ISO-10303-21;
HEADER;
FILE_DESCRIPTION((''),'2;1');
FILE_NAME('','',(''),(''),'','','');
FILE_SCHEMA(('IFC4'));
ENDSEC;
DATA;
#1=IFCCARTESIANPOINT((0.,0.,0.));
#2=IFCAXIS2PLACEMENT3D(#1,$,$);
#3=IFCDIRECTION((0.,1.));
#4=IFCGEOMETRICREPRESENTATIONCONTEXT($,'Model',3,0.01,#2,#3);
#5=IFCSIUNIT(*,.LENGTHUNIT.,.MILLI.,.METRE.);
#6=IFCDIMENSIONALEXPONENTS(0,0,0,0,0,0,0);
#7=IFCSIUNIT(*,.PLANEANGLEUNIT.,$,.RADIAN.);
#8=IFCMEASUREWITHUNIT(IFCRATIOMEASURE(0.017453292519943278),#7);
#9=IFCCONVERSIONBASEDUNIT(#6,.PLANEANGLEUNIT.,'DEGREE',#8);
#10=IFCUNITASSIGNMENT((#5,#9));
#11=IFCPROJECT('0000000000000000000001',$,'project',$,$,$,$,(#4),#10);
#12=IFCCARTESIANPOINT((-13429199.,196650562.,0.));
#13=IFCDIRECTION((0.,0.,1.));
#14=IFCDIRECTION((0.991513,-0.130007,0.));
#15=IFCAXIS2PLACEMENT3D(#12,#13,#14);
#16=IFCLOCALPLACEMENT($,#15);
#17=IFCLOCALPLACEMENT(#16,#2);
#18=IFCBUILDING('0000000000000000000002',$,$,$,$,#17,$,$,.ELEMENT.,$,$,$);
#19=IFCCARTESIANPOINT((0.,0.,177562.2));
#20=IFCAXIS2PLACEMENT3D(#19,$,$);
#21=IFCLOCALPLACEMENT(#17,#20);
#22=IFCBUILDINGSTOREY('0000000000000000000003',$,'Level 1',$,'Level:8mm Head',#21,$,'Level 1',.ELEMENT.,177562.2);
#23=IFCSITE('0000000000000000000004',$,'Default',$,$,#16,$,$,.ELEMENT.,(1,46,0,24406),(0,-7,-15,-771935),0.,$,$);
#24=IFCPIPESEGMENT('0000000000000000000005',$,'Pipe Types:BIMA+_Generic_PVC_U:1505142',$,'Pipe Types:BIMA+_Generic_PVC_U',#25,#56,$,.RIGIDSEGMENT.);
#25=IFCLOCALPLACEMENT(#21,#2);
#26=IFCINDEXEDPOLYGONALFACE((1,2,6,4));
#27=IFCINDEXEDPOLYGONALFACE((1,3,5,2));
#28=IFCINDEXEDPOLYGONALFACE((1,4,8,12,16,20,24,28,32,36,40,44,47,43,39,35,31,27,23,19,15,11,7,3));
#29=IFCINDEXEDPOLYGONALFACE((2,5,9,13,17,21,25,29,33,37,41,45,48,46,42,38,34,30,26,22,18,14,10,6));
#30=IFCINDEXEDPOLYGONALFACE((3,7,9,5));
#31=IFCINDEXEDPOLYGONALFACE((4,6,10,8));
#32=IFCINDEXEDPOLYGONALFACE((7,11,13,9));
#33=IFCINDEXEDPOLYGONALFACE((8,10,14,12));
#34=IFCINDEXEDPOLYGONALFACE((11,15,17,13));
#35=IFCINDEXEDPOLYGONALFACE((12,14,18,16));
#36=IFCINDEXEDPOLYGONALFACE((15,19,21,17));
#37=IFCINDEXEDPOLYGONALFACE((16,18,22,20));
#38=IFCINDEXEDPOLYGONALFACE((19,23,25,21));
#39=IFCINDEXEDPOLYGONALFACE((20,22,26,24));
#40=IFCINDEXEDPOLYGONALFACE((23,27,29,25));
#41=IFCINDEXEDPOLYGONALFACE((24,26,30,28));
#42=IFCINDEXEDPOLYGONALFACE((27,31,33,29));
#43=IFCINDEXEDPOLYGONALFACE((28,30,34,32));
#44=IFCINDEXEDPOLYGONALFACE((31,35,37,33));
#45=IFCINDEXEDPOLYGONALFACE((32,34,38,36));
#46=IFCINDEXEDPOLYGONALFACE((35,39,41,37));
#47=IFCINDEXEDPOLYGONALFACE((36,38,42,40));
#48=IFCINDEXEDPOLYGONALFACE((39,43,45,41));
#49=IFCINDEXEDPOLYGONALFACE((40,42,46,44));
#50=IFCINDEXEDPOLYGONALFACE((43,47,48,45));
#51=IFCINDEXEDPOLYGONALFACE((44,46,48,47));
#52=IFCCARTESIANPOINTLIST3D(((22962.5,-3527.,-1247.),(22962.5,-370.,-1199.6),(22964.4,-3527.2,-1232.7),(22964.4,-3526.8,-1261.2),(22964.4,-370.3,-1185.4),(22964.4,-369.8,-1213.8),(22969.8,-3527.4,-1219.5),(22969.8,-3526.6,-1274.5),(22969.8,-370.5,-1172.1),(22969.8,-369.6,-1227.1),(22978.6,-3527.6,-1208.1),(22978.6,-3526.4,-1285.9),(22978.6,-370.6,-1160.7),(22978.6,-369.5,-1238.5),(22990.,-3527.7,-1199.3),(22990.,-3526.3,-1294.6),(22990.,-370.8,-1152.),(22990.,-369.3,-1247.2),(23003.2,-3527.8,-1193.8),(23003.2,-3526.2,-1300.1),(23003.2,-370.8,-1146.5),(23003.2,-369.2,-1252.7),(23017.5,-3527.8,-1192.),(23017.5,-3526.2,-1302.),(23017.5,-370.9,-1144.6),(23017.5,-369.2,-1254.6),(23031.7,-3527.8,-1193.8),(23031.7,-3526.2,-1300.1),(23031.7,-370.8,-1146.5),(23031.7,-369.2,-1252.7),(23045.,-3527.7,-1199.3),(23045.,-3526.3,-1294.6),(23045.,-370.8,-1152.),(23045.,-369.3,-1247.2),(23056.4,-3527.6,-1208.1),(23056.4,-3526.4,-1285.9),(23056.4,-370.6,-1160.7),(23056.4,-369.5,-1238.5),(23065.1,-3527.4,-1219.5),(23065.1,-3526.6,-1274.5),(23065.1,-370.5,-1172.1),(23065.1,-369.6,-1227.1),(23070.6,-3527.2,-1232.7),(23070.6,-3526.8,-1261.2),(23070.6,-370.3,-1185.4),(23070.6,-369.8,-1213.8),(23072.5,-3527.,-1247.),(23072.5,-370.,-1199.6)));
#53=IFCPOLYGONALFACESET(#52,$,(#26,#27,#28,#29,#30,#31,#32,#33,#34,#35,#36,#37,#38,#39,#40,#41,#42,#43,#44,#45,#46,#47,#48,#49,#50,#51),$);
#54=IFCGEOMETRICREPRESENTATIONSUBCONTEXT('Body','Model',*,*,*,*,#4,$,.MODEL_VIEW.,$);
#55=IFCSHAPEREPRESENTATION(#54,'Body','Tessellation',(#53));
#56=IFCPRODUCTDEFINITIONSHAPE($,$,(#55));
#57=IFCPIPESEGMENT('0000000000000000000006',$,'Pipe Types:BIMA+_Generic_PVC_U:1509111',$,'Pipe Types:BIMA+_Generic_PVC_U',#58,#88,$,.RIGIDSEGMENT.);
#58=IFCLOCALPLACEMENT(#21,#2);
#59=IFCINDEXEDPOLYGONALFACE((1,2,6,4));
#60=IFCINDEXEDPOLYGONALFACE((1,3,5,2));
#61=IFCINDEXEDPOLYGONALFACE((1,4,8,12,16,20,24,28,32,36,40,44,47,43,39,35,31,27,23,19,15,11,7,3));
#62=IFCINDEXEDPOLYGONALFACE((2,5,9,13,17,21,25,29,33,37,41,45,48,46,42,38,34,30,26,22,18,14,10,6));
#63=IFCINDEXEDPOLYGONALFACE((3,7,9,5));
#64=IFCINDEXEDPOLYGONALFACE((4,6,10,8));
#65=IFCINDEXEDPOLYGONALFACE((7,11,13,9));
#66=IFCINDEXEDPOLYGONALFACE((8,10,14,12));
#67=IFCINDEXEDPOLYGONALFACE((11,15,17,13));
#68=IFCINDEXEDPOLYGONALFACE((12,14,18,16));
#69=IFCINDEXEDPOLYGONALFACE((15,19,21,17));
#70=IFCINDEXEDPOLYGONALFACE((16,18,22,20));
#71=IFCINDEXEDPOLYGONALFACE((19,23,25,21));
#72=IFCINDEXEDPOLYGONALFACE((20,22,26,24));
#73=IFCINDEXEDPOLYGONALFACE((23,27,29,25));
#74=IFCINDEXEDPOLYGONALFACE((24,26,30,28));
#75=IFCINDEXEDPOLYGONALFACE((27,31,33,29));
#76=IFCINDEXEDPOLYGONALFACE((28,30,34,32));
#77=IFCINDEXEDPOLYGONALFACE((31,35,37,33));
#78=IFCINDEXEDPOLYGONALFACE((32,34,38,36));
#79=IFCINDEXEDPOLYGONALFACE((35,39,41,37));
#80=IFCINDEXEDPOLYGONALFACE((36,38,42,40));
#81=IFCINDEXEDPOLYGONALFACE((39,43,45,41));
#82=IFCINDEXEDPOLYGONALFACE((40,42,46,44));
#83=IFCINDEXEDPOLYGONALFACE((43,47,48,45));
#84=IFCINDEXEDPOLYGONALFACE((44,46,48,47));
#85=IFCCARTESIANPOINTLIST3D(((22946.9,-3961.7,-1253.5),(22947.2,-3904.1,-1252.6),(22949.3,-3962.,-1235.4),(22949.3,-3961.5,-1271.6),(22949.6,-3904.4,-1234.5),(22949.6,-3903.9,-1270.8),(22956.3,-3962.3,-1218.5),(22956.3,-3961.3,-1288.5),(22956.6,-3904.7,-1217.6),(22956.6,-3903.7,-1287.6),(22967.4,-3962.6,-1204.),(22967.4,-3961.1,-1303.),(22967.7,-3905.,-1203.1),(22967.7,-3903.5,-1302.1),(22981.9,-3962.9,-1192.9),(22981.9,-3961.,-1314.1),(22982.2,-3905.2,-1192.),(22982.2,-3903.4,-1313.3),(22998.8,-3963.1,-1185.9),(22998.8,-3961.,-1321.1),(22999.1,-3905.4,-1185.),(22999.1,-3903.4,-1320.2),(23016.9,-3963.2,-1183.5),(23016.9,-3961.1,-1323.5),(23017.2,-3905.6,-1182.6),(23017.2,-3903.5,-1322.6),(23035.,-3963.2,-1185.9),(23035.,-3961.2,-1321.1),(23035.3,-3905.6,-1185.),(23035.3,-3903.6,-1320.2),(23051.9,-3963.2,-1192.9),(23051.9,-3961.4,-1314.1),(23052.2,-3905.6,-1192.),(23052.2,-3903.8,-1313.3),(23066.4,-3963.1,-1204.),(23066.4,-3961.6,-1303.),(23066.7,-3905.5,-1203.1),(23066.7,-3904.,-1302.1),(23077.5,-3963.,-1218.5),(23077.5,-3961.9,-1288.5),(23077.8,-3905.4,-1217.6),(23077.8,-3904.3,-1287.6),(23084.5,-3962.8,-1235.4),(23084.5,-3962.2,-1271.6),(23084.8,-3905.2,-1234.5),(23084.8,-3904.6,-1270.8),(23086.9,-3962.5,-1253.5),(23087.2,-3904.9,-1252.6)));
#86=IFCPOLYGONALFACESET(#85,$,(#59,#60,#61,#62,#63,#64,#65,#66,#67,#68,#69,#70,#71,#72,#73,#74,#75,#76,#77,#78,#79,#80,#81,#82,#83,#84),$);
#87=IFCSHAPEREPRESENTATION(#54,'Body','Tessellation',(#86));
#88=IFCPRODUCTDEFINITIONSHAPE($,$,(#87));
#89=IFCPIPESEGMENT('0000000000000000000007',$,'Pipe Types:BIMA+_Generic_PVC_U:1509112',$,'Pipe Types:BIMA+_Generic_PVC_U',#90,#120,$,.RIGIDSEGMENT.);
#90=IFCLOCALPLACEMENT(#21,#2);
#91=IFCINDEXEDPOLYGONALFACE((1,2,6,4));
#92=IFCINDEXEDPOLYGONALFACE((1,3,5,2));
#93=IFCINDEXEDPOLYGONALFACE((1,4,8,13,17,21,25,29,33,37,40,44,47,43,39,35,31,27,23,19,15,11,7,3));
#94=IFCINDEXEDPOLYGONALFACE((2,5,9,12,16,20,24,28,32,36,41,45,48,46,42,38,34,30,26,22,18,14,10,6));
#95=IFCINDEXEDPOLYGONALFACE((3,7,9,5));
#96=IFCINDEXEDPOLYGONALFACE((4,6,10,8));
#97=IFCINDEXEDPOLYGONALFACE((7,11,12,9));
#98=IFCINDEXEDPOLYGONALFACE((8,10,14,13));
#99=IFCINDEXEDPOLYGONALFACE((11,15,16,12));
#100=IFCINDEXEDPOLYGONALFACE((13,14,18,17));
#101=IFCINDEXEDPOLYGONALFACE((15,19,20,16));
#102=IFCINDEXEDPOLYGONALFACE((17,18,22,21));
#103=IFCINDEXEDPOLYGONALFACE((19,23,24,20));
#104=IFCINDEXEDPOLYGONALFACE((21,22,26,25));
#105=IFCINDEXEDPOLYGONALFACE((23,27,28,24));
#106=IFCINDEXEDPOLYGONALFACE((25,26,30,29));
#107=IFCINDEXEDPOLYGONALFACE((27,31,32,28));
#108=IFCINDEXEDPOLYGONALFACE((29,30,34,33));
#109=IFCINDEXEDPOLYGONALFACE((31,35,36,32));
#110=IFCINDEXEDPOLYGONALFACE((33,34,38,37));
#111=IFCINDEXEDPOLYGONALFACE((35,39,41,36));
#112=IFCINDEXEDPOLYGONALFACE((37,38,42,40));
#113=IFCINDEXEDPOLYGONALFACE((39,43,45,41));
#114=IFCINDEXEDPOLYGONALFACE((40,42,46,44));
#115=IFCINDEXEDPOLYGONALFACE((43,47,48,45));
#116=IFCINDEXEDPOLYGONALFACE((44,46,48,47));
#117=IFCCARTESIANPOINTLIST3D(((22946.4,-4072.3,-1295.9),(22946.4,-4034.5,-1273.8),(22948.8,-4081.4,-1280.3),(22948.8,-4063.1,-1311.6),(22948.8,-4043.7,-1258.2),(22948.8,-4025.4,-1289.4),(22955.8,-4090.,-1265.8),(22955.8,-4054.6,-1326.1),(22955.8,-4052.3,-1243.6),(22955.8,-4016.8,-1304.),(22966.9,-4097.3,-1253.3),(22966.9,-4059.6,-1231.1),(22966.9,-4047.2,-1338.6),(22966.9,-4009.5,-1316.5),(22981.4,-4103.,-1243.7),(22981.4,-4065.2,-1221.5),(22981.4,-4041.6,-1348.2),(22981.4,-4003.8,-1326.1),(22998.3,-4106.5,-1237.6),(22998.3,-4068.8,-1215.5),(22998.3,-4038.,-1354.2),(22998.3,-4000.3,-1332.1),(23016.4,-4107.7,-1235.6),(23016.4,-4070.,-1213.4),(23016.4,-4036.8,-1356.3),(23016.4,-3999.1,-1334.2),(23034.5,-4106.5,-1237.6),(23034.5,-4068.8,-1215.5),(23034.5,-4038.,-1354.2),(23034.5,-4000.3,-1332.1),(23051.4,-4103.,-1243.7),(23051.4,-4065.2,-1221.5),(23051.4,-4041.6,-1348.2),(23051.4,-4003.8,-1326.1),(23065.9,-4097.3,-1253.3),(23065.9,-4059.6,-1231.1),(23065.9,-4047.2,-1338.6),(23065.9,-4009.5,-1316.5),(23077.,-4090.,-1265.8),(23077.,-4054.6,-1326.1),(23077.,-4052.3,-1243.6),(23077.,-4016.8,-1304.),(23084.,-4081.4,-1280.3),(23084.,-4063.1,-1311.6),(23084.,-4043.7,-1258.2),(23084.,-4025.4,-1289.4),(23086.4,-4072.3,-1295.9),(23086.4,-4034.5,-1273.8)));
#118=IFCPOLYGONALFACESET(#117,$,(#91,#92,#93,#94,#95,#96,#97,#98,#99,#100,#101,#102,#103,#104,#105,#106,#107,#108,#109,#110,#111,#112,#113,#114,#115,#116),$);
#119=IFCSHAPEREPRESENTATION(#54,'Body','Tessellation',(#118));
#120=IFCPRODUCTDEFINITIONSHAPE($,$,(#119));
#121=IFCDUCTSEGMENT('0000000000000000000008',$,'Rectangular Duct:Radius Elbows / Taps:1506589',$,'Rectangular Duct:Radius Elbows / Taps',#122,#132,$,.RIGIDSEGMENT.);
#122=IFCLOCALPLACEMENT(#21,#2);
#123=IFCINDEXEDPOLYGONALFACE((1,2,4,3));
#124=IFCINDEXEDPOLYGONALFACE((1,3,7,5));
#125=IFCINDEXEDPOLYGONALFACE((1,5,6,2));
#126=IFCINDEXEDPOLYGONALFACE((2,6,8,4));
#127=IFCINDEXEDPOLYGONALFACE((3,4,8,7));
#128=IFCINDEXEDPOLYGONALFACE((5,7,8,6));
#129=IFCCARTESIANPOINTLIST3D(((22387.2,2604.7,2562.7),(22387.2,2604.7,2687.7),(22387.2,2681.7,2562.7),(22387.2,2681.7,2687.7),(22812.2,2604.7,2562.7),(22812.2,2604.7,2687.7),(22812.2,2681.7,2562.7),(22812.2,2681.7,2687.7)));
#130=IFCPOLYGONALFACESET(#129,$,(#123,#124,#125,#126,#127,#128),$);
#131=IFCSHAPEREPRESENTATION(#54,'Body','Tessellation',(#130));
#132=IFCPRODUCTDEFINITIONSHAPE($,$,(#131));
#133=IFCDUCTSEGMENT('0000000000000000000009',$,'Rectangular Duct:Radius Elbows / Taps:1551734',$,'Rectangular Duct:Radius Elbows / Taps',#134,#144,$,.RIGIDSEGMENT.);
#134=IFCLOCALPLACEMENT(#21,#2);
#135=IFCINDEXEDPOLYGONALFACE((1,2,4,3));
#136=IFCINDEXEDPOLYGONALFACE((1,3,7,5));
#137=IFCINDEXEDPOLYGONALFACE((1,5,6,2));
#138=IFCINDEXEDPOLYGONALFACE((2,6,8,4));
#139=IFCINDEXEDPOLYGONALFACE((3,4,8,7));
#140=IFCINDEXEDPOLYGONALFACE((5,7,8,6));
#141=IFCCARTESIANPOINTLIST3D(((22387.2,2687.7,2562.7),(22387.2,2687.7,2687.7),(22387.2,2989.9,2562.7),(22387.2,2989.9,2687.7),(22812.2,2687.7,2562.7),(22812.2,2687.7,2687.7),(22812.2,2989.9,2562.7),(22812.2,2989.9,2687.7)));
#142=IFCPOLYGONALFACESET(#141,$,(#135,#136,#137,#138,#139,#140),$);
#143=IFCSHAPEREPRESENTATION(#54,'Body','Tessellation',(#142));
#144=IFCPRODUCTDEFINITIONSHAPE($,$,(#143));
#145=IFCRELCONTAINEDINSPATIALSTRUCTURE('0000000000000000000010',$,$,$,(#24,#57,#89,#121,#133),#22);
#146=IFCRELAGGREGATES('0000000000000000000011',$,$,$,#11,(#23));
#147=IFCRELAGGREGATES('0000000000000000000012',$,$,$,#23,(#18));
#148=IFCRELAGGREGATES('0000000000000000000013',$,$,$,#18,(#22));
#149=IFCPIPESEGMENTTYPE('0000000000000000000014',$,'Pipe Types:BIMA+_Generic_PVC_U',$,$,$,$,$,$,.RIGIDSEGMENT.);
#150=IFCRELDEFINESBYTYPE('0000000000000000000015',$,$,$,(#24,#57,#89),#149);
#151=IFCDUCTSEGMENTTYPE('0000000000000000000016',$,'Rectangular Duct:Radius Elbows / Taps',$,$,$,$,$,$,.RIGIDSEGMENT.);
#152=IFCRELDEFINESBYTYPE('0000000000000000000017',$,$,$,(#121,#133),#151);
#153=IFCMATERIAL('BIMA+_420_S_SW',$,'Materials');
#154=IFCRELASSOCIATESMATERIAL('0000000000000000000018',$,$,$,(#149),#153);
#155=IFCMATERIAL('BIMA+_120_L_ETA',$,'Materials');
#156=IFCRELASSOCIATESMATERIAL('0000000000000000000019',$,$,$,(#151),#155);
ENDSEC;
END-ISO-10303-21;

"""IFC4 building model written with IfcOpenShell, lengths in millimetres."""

from ifc_helpers import new_model, entity, si_unit, converted_unit, direction, frame, origin, place, context, subcontext, project, spatial, arc, indexed_curve, outline, extrude, material, type_object, element, save


model = new_model("IFC4")

# Units and contexts
model_context = context("Model", 3, precision=0.01, world=origin(), true_north=direction((0.0, 1.0)))
body_context = subcontext(model_context, "Body", "Model", "MODEL_VIEW")
ifc_project = project(units=[si_unit("LENGTHUNIT", "METRE", prefix="MILLI"), converted_unit("PLANEANGLEUNIT", "DEGREE", entity("IfcRatioMeasure", 0.017453292519943278), si_unit("PLANEANGLEUNIT", "RADIAN"), dimensions=[0, 0, 0, 0, 0, 0, 0])], contexts=[model_context])

# Site, building, storey
site_placement = place(None, frame((-13429199.0, 196650562.0, 0.0), z_axis=(0.0, 0.0, 1.0), x_axis=(0.991513, -0.130007, 0.0)))
site = spatial("IfcSite", under=ifc_project, at=site_placement, Name="Default", CompositionType="ELEMENT", RefLatitude=(1, 46, 0, 24406), RefLongitude=(0, -7, -15, -771935), RefElevation=0.0)
building_placement = place(site_placement, origin())
building = spatial("IfcBuilding", under=site, at=building_placement, CompositionType="ELEMENT")
storey_placement = place(building_placement, frame((0.0, 0.0, 177562.2)))
storey = spatial("IfcBuildingStorey", under=building, at=storey_placement, Name="Level 1", ObjectType="Level:8mm Head", LongName="Level 1", CompositionType="ELEMENT", Elevation=177562.2)

# Pipe segments
ifc_material_1 = material(Name="BIMA+_420_S_SW", Category="Materials")
pipe_segment_type_1 = type_object("IfcPipeSegmentType", Name="Pipe Types:BIMA+_Generic_PVC_U", PredefinedType="RIGIDSEGMENT", material=ifc_material_1)
pipe_segment_1_placement = place(storey_placement, frame((22960.9, -3529.4, -1303.6)))
element("IfcPipeSegment", 1, at=pipe_segment_1_placement, inside=storey, type_object=pipe_segment_type_1, Name="Pipe Types:BIMA+_Generic_PVC_U:1505142", ObjectType="Pipe Types:BIMA+_Generic_PVC_U", PredefinedType="RIGIDSEGMENT", context=body_context, shape_type="SweptSolid", body=[
    extrude(outline(indexed_curve([(55.0, 0.0), (38.9, 38.9), (0.0, 55.0), (-38.9, 38.9), (-55.0, 0.0), (-38.9, -38.9), (0.0, -55.0), (38.9, -38.9)], segments=[arc(1, 2, 3), arc(3, 4, 5), arc(5, 6, 7), arc(7, 8, 1)], self_intersect=False)), frame((56.6, 2.4, 56.6), z_axis=(0.0, 0.999888, 0.014998), x_axis=(-1.0, 0.0, 0.0)), (0.0, 0.0, 1.0), 3157.3),
])
pipe_segment_2_placement = place(storey_placement, frame((22945.3, -3964.8, -1325.1)))
element("IfcPipeSegment", 2, at=pipe_segment_2_placement, inside=storey, type_object=pipe_segment_type_1, Name="Pipe Types:BIMA+_Generic_PVC_U:1509111", ObjectType="Pipe Types:BIMA+_Generic_PVC_U", PredefinedType="RIGIDSEGMENT", context=body_context, shape_type="SweptSolid", body=[
    extrude(outline(indexed_curve([(70.0, 0.0), (49.5, 49.5), (0.0, 70.0), (-49.5, 49.5), (-70.0, 0.0), (-49.5, -49.5), (0.0, -70.0), (49.5, -49.5)], segments=[arc(1, 2, 3), arc(3, 4, 5), arc(5, 6, 7), arc(7, 8, 1)], self_intersect=False)), frame((71.6, 2.7, 71.6), z_axis=(0.005403, 0.999871, 0.015109), x_axis=(-0.999985, 0.005404, 0.0)), (0.0, 0.0, 1.0), 57.6),
])
pipe_segment_3_placement = place(storey_placement, frame((22944.8, -4109.3, -1357.9)))
element("IfcPipeSegment", 3, at=pipe_segment_3_placement, inside=storey, type_object=pipe_segment_type_1, Name="Pipe Types:BIMA+_Generic_PVC_U:1509112", ObjectType="Pipe Types:BIMA+_Generic_PVC_U", PredefinedType="RIGIDSEGMENT", context=body_context, shape_type="SweptSolid", body=[
    extrude(outline(indexed_curve([(70.0, 0.0), (49.5, 49.5), (0.0, 70.0), (-49.5, 49.5), (-70.0, 0.0), (-49.5, -49.5), (0.0, -70.0), (49.5, -49.5)], segments=[arc(1, 2, 3), arc(3, 4, 5), arc(5, 6, 7), arc(7, 8, 1)], self_intersect=False)), frame((71.6, 37.0, 62.0), z_axis=(0.0, 0.862299, 0.5064), x_axis=(-1.0, 0.0, 0.0)), (0.0, 0.0, 1.0), 43.8),
])

# Duct segments
ifc_material_2 = material(Name="BIMA+_120_L_ETA", Category="Materials")
duct_segment_type = type_object("IfcDuctSegmentType", Name="Rectangular Duct:Radius Elbows / Taps", PredefinedType="RIGIDSEGMENT", material=ifc_material_2)
duct_segment_1_placement = place(storey_placement, frame((22387.2, 2604.7, 2562.7)))
element("IfcDuctSegment", 4, at=duct_segment_1_placement, inside=storey, type_object=duct_segment_type, Name="Rectangular Duct:Radius Elbows / Taps:1506589", ObjectType="Rectangular Duct:Radius Elbows / Taps", PredefinedType="RIGIDSEGMENT", context=body_context, shape_type="SweptSolid", body=[
    extrude(outline(indexed_curve([(-38.5, -212.5), (38.5, -212.5), (38.5, 212.5), (-38.5, 212.5), (-38.5, -212.5)], self_intersect=False)), frame((212.5, 38.5, 0.0), z_axis=(0.0, 0.0, 1.0), x_axis=(0.0, -1.0, 0.0)), (0.0, 0.0, 1.0), 125.0),
])
duct_segment_2_placement = place(storey_placement, frame((22387.2, 2687.7, 2562.7)))
element("IfcDuctSegment", 5, at=duct_segment_2_placement, inside=storey, type_object=duct_segment_type, Name="Rectangular Duct:Radius Elbows / Taps:1551734", ObjectType="Rectangular Duct:Radius Elbows / Taps", PredefinedType="RIGIDSEGMENT", context=body_context, shape_type="SweptSolid", body=[
    extrude(outline(indexed_curve([(-151.1, -212.5), (151.1, -212.5), (151.1, 212.5), (-151.1, 212.5), (-151.1, -212.5)], self_intersect=False)), frame((212.5, 151.1, 0.0), z_axis=(0.0, 0.0, 1.0), x_axis=(0.0, -1.0, 0.0)), (0.0, 0.0, 1.0), 125.0),
])

save(model, "model.ifc")
